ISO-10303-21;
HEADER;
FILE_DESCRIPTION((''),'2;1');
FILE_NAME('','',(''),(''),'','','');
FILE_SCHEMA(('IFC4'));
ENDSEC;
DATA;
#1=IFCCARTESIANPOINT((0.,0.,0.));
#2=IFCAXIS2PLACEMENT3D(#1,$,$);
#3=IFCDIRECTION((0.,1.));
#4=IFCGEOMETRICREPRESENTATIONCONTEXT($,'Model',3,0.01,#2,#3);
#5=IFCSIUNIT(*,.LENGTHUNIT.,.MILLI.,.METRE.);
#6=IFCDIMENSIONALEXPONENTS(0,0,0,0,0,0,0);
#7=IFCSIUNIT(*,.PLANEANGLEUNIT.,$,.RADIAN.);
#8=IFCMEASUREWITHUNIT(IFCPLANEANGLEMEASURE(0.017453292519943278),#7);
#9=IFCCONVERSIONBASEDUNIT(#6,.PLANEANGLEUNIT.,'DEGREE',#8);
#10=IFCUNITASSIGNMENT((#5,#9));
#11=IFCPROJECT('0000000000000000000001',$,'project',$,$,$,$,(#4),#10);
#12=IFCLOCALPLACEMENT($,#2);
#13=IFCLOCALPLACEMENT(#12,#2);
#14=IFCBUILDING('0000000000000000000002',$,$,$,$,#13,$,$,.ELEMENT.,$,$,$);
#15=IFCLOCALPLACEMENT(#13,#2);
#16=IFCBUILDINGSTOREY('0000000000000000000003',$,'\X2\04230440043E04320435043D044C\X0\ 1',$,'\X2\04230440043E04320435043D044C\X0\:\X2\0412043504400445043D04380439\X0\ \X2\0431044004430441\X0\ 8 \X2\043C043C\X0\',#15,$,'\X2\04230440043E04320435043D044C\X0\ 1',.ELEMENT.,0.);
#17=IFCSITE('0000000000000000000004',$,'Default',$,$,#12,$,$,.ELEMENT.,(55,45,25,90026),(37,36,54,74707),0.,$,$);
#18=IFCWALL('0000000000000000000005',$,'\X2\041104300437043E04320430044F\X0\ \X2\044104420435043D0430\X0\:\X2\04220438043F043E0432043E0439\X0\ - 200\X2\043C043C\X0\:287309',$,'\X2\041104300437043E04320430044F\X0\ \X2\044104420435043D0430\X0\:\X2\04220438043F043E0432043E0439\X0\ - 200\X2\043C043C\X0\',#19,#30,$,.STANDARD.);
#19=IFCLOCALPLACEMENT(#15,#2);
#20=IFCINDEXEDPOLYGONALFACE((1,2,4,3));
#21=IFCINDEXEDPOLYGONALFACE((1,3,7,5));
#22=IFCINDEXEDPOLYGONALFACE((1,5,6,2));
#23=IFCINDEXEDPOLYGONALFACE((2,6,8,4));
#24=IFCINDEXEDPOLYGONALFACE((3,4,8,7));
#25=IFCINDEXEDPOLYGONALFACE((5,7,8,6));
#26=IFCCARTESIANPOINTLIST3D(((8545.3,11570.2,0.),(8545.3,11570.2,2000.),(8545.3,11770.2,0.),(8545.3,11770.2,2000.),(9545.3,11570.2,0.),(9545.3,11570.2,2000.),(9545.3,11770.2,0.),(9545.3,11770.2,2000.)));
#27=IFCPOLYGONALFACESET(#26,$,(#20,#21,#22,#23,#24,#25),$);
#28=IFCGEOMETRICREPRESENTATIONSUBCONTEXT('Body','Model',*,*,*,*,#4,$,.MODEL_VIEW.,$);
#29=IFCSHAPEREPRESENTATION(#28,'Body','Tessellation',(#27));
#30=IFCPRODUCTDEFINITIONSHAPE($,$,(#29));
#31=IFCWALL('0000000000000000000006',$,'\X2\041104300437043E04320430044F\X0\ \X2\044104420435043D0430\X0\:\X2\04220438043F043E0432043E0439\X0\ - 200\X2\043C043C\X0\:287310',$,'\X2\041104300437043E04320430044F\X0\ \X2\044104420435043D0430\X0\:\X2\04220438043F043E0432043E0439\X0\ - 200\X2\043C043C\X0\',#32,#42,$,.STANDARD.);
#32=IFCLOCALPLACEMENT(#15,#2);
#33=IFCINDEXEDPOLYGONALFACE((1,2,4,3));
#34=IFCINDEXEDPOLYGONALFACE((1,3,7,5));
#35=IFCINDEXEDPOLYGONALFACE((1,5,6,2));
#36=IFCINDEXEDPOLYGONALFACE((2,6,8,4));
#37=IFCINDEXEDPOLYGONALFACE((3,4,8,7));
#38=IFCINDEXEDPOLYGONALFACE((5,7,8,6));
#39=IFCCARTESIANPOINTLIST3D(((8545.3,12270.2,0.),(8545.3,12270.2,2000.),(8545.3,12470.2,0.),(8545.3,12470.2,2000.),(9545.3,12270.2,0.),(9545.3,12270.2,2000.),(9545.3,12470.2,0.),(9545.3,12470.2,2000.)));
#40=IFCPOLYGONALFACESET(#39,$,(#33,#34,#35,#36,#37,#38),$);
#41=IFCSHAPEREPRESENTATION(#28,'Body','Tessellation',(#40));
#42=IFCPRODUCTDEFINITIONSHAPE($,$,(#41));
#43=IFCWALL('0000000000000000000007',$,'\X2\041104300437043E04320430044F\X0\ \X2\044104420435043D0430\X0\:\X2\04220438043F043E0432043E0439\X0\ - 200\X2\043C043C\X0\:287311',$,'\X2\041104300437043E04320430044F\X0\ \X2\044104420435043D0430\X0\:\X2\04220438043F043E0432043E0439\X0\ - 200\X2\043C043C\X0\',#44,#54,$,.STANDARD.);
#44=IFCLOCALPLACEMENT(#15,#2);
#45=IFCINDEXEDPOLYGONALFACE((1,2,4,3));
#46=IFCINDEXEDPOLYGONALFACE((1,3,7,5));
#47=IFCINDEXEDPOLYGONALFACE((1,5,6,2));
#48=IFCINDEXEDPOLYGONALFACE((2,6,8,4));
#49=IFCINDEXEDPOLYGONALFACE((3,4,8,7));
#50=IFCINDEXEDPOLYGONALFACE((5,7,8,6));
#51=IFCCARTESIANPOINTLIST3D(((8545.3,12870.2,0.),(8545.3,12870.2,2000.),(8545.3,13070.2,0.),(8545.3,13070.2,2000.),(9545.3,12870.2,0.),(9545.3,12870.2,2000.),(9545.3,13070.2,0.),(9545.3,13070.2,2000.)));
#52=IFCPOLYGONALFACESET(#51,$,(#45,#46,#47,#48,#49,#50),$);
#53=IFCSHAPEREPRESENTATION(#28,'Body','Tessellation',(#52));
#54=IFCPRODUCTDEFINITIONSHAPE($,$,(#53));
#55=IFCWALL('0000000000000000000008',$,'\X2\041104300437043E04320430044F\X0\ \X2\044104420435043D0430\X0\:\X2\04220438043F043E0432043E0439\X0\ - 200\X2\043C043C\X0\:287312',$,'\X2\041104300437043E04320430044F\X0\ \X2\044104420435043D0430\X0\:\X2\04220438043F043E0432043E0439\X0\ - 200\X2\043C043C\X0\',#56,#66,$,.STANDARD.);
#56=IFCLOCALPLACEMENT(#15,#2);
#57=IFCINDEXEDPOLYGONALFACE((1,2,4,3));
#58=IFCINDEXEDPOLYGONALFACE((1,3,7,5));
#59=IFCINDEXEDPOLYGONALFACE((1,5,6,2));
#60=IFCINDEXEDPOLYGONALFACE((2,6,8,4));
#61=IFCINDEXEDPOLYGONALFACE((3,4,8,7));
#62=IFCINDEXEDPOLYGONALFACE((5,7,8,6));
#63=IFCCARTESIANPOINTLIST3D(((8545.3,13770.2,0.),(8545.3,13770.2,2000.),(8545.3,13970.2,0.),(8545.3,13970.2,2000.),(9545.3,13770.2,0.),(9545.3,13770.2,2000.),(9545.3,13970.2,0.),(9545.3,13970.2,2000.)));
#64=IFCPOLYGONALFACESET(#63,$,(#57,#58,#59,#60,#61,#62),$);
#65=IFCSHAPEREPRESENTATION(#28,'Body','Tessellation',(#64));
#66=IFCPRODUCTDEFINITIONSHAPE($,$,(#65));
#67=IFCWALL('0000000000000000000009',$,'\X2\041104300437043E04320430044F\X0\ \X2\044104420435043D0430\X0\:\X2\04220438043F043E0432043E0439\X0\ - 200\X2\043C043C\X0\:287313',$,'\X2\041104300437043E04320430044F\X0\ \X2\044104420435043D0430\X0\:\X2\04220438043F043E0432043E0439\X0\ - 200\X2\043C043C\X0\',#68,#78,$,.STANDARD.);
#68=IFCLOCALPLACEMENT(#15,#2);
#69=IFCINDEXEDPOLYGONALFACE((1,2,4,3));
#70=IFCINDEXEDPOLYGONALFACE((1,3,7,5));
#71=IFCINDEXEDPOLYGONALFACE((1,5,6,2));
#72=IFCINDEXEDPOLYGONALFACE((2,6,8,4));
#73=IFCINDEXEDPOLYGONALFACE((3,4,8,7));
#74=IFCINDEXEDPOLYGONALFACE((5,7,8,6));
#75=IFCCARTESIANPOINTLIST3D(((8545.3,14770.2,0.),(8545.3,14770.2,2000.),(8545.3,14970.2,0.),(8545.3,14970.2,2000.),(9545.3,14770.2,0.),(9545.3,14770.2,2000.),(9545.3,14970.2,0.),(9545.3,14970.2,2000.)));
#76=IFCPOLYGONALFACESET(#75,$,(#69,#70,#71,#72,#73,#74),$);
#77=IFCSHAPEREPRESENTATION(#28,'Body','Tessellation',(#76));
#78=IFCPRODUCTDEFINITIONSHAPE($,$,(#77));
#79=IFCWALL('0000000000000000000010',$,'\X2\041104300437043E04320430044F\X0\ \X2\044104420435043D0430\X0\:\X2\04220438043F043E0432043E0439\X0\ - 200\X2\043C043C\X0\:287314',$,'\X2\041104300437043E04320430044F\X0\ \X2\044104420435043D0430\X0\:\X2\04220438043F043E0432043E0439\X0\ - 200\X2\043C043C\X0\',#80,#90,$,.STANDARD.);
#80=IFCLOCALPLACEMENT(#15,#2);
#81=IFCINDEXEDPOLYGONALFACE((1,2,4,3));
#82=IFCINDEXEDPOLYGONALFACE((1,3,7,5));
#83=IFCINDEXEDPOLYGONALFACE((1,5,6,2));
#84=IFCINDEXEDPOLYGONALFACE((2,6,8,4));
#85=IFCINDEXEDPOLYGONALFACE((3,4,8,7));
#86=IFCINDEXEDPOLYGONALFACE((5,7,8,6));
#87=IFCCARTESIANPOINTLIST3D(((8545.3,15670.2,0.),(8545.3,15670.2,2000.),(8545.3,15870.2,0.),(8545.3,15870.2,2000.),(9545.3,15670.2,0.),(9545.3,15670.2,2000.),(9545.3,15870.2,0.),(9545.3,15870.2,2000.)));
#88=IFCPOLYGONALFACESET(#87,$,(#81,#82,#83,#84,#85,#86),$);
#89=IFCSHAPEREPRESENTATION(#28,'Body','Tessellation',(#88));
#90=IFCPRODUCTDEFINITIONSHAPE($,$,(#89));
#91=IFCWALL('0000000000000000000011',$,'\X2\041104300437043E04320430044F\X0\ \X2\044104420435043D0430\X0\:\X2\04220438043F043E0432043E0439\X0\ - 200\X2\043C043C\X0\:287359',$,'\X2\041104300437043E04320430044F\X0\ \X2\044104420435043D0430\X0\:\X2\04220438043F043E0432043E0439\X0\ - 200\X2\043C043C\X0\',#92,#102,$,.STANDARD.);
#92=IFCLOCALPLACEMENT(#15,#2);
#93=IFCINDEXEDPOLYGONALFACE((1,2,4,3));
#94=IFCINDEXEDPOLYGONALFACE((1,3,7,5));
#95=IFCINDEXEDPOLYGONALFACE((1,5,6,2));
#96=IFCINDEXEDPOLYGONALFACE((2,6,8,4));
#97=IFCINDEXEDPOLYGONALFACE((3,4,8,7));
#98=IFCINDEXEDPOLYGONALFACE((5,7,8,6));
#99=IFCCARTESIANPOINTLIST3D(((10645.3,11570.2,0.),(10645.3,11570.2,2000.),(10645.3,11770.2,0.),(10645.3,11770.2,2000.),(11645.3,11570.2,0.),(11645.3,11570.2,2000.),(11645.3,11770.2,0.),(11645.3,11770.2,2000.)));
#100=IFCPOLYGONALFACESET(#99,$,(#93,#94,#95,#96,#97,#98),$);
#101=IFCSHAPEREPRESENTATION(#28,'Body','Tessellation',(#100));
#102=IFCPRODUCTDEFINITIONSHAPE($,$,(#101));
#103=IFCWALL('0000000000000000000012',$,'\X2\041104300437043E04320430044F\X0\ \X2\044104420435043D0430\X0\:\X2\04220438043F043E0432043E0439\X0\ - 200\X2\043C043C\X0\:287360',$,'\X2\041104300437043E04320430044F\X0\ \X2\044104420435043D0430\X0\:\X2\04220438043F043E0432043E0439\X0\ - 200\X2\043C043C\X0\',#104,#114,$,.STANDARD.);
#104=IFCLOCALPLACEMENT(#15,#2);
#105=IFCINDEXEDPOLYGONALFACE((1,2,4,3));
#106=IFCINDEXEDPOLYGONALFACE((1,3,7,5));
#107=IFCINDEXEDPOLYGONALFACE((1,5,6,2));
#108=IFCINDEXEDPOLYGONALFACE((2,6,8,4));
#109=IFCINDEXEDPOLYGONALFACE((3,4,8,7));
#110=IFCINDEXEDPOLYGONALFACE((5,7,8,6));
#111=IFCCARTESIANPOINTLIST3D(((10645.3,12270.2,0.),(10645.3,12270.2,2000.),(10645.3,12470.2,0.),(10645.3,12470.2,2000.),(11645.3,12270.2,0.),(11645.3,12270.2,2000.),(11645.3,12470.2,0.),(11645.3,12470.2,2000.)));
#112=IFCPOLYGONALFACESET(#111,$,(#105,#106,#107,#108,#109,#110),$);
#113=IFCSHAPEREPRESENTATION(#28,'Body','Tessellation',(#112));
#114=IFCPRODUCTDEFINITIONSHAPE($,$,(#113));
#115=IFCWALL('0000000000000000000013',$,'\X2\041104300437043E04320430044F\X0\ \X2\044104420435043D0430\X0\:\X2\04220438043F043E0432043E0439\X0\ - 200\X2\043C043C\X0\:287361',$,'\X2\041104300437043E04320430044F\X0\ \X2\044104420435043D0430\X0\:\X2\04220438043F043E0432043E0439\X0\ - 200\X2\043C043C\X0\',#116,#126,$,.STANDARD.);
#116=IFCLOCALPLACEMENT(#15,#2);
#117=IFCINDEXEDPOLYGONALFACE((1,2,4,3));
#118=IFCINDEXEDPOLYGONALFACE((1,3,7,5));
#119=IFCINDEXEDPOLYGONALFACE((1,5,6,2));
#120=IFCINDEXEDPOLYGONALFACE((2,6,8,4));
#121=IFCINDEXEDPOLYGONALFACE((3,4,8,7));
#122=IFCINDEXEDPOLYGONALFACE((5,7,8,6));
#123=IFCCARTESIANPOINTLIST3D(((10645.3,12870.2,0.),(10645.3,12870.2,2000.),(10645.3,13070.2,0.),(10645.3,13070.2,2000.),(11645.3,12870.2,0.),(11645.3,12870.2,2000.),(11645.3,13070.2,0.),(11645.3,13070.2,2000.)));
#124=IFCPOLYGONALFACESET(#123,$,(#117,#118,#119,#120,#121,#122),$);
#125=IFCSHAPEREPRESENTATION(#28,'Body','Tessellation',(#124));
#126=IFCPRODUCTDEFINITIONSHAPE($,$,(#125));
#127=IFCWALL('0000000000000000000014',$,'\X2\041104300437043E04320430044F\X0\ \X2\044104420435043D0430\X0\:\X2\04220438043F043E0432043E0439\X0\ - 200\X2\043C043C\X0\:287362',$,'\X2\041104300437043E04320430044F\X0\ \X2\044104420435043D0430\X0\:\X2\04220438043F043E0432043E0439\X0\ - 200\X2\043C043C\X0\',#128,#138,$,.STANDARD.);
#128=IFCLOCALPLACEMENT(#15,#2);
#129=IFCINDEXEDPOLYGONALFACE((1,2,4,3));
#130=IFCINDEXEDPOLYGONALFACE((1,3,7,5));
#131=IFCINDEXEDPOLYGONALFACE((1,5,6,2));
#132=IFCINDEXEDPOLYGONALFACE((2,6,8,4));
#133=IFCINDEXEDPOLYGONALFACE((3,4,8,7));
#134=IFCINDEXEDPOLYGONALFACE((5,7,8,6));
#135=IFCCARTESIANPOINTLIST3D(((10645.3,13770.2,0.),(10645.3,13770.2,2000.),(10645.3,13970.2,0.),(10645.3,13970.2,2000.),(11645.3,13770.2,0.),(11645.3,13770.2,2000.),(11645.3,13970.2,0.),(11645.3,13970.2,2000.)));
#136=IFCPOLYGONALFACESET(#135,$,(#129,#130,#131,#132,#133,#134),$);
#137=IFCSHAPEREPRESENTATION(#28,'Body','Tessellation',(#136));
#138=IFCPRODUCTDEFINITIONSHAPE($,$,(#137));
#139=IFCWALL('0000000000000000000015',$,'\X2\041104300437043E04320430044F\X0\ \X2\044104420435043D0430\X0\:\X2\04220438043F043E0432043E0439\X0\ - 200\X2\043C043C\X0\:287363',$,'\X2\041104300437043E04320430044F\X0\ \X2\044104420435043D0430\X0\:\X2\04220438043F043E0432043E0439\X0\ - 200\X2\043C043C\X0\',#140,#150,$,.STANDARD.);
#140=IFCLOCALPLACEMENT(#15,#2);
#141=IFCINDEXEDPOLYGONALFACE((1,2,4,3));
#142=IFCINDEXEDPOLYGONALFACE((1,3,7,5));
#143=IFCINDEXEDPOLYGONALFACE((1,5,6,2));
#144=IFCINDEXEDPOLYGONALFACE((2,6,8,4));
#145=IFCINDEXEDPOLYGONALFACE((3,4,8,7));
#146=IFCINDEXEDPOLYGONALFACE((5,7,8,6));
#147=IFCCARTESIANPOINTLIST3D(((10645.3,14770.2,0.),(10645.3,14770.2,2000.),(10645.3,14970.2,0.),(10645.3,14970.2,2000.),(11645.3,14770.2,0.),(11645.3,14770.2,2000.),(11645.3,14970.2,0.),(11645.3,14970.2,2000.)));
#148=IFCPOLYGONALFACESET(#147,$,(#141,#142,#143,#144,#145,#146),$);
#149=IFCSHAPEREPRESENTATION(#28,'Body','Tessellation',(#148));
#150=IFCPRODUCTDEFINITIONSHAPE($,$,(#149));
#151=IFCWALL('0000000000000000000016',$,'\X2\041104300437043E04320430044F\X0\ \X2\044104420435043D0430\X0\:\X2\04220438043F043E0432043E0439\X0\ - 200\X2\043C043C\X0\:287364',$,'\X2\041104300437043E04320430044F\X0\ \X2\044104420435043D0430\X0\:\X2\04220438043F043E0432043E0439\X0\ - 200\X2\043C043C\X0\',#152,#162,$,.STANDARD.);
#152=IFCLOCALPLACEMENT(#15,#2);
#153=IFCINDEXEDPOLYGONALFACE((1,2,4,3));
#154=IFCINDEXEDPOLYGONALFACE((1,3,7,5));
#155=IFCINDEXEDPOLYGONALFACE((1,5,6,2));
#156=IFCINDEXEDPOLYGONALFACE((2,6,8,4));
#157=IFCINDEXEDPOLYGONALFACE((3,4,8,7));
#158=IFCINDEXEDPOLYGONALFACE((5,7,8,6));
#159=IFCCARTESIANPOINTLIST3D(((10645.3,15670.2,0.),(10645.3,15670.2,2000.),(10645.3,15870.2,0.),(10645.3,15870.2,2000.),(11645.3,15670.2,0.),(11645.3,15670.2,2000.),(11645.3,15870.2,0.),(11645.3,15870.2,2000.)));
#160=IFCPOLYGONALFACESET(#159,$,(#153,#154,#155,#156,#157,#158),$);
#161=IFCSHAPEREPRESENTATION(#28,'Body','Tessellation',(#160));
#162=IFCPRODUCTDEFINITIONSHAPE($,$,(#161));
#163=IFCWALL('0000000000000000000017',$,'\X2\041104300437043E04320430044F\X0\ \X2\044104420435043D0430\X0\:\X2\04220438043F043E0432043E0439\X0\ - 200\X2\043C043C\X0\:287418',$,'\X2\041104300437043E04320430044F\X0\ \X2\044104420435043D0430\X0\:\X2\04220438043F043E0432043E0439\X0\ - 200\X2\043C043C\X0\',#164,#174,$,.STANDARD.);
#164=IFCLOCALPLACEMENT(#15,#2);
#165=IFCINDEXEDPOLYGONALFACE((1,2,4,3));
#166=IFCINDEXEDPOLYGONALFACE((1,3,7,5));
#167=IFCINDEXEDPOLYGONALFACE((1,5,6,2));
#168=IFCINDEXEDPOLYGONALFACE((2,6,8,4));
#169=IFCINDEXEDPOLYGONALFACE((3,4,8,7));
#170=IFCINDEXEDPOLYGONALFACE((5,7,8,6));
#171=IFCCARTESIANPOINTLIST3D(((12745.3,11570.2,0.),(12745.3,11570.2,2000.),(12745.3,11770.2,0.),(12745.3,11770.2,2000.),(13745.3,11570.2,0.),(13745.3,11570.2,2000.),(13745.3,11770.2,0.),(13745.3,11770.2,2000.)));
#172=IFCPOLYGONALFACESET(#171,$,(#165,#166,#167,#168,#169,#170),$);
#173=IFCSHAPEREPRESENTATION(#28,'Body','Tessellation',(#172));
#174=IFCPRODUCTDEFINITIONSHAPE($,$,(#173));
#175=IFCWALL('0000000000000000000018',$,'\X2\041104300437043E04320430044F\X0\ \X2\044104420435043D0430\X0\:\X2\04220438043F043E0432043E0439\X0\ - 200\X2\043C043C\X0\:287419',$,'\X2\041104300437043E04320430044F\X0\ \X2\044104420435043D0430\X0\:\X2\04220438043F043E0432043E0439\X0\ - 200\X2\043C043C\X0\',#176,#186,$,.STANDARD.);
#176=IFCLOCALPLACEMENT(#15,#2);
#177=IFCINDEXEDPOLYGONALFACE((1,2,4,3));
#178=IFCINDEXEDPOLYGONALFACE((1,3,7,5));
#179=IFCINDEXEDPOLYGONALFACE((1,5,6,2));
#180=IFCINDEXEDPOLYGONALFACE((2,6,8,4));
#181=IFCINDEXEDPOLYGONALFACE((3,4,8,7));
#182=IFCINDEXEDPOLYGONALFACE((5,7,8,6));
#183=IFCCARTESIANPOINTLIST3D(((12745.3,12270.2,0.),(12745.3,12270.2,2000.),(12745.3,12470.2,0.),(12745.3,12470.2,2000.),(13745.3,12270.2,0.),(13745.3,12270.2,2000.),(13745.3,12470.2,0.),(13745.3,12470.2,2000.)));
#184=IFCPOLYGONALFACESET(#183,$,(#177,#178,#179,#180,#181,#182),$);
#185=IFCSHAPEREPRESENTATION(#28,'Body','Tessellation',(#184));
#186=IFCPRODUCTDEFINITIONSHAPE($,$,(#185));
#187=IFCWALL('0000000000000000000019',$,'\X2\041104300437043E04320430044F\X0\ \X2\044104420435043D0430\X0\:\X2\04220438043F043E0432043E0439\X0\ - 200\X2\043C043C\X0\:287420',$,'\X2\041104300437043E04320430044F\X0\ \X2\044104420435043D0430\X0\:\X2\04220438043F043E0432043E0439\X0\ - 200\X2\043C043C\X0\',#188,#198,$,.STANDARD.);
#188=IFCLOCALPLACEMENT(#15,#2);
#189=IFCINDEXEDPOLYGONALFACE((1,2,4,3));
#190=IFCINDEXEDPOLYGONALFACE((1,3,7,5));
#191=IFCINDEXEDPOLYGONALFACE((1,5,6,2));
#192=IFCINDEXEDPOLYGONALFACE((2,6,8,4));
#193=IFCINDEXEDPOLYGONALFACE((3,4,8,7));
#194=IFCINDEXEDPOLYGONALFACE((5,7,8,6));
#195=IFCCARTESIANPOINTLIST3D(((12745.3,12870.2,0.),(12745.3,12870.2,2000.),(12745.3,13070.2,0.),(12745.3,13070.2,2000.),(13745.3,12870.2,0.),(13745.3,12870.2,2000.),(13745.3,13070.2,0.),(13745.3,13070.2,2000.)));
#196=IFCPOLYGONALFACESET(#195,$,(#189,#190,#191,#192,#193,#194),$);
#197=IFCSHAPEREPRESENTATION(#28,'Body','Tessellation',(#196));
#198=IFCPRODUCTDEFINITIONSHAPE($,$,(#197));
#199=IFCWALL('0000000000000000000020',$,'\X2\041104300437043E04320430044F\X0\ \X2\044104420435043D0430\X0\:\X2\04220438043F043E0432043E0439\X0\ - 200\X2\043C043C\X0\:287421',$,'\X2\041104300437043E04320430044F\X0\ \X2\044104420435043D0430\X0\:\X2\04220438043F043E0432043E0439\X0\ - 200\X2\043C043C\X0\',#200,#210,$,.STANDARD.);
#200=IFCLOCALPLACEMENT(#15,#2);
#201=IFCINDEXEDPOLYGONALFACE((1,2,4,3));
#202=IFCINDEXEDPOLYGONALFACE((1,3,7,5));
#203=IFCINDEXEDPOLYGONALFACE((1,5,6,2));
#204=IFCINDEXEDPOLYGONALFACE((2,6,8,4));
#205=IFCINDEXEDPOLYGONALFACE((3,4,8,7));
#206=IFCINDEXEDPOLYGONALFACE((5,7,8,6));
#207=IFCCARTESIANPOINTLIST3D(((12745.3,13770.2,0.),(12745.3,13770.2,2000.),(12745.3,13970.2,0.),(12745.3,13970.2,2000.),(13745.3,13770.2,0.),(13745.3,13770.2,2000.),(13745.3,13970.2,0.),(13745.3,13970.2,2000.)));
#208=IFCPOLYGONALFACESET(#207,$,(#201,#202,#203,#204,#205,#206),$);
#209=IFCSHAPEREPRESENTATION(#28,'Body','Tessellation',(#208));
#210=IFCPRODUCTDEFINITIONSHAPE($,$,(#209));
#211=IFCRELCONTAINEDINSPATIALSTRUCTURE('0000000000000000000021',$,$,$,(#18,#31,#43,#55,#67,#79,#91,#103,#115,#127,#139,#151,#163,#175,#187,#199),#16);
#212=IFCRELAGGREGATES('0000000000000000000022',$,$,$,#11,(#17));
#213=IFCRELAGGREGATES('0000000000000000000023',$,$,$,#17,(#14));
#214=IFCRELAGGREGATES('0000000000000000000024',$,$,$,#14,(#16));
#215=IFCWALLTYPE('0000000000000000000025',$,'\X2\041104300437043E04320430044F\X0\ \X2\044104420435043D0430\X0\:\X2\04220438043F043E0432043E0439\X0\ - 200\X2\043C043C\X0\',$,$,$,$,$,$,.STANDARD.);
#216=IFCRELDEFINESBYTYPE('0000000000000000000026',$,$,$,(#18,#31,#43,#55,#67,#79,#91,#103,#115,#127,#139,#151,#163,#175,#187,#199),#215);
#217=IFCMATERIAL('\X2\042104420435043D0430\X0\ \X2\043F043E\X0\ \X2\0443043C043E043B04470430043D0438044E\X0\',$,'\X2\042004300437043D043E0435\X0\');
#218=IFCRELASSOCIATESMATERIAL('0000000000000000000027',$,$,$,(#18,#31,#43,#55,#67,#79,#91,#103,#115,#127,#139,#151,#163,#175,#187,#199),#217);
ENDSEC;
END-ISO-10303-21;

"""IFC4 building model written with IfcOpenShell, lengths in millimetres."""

from ifc_helpers import new_model, entity, si_unit, converted_unit, direction, frame, origin, place, context, subcontext, project, spatial, indexed_curve, outline, extrude, material, type_object, element, save


model = new_model("IFC4")

# Units and contexts
model_context = context("Model", 3, precision=0.01, world=origin(), true_north=direction((0.0, 1.0)))
body_context = subcontext(model_context, "Body", "Model", "MODEL_VIEW")
ifc_project = project(units=[si_unit("LENGTHUNIT", "METRE", prefix="MILLI"), converted_unit("PLANEANGLEUNIT", "DEGREE", entity("IfcPlaneAngleMeasure", 0.017453292519943278), si_unit("PLANEANGLEUNIT", "RADIAN"), dimensions=[0, 0, 0, 0, 0, 0, 0])], contexts=[model_context])

# Site, building, storey
site_placement = place(None, origin())
site = spatial("IfcSite", under=ifc_project, at=site_placement, Name="Default", CompositionType="ELEMENT", RefLatitude=(55, 45, 25, 90026), RefLongitude=(37, 36, 54, 74707), RefElevation=0.0)
building_placement = place(site_placement, origin())
building = spatial("IfcBuilding", under=site, at=building_placement, CompositionType="ELEMENT")
storey_placement = place(building_placement, origin())
storey = spatial("IfcBuildingStorey", under=building, at=storey_placement, Name="Уровень 1", ObjectType="Уровень:Верхний брус 8 мм", LongName="Уровень 1", CompositionType="ELEMENT", Elevation=0.0)

# Walls
ifc_material = material(Name="Стена по умолчанию", Category="Разное")
wall_type = type_object("IfcWallType", Name="Базовая стена:Типовой - 200мм", PredefinedType="STANDARD")
for number, where, name in (
    (1, (8545.3, 11670.2, 0.0), "Базовая стена:Типовой - 200мм:287309"),
    (2, (8545.3, 12370.2, 0.0), "Базовая стена:Типовой - 200мм:287310"),
):
    element("IfcWall", number, at=place(storey_placement, frame(where)), inside=storey, type_object=wall_type, material=ifc_material, Name=name, ObjectType="Базовая стена:Типовой - 200мм", PredefinedType="STANDARD", context=body_context, shape_type="SweptSolid", body=[
        extrude(outline(indexed_curve([(1000.0, 100.0), (0.0, 100.0), (0.0, -100.0), (1000.0, -100.0), (1000.0, 100.0)], self_intersect=False)), origin(), (0.0, 0.0, 1.0), 2000.0),
    ])
wall_1_placement = place(storey_placement, frame((8545.3, 12970.2, 0.0)))
element("IfcWall", 3, at=wall_1_placement, inside=storey, type_object=wall_type, material=ifc_material, Name="Базовая стена:Типовой - 200мм:287311", ObjectType="Базовая стена:Типовой - 200мм", PredefinedType="STANDARD", context=body_context, shape_type="SweptSolid", body=[
    extrude(outline(indexed_curve([(1000.0, 100.0), (0.0, 100.0), (0.0, -100.0), (1000.0, -100.0), (1000.0, 100.0)], self_intersect=False)), origin(), (0.0, 0.0, 1.0), 2000.0),
])
wall_2_placement = place(storey_placement, frame((8545.3, 13870.2, 0.0)))
element("IfcWall", 4, at=wall_2_placement, inside=storey, type_object=wall_type, material=ifc_material, Name="Базовая стена:Типовой - 200мм:287312", ObjectType="Базовая стена:Типовой - 200мм", PredefinedType="STANDARD", context=body_context, shape_type="SweptSolid", body=[
    extrude(outline(indexed_curve([(1000.0, 100.0), (0.0, 100.0), (0.0, -100.0), (1000.0, -100.0), (1000.0, 100.0)], self_intersect=False)), origin(), (0.0, 0.0, 1.0), 2000.0),
])
for number, where, name in (
    (5, (8545.3, 14870.2, 0.0), "Базовая стена:Типовой - 200мм:287313"),
    (6, (8545.3, 15770.2, 0.0), "Базовая стена:Типовой - 200мм:287314"),
):
    element("IfcWall", number, at=place(storey_placement, frame(where)), inside=storey, type_object=wall_type, material=ifc_material, Name=name, ObjectType="Базовая стена:Типовой - 200мм", PredefinedType="STANDARD", context=body_context, shape_type="SweptSolid", body=[
        extrude(outline(indexed_curve([(1000.0, 100.0), (0.0, 100.0), (0.0, -100.0), (1000.0, -100.0), (1000.0, 100.0)], self_intersect=False)), origin(), (0.0, 0.0, 1.0), 2000.0),
    ])
for number, where, name in (
    (7, (10645.3, 11670.2, 0.0), "Базовая стена:Типовой - 200мм:287359"),
    (8, (10645.3, 12370.2, 0.0), "Базовая стена:Типовой - 200мм:287360"),
):
    element("IfcWall", number, at=place(storey_placement, frame(where)), inside=storey, type_object=wall_type, material=ifc_material, Name=name, ObjectType="Базовая стена:Типовой - 200мм", PredefinedType="STANDARD", context=body_context, shape_type="SweptSolid", body=[
        extrude(outline(indexed_curve([(1000.0, 100.0), (0.0, 100.0), (0.0, -100.0), (1000.0, -100.0), (1000.0, 100.0)], self_intersect=False)), origin(), (0.0, 0.0, 1.0), 2000.0),
    ])
wall_3_placement = place(storey_placement, frame((10645.3, 12970.2, 0.0)))
element("IfcWall", 9, at=wall_3_placement, inside=storey, type_object=wall_type, material=ifc_material, Name="Базовая стена:Типовой - 200мм:287361", ObjectType="Базовая стена:Типовой - 200мм", PredefinedType="STANDARD", context=body_context, shape_type="SweptSolid", body=[
    extrude(outline(indexed_curve([(1000.0, 100.0), (0.0, 100.0), (0.0, -100.0), (1000.0, -100.0), (1000.0, 100.0)], self_intersect=False)), origin(), (0.0, 0.0, 1.0), 2000.0),
])
wall_4_placement = place(storey_placement, frame((10645.3, 13870.2, 0.0)))
element("IfcWall", 10, at=wall_4_placement, inside=storey, type_object=wall_type, material=ifc_material, Name="Базовая стена:Типовой - 200мм:287362", ObjectType="Базовая стена:Типовой - 200мм", PredefinedType="STANDARD", context=body_context, shape_type="SweptSolid", body=[
    extrude(outline(indexed_curve([(1000.0, 100.0), (0.0, 100.0), (0.0, -100.0), (1000.0, -100.0), (1000.0, 100.0)], self_intersect=False)), origin(), (0.0, 0.0, 1.0), 2000.0),
])
for number, where, name in (
    (11, (10645.3, 14870.2, 0.0), "Базовая стена:Типовой - 200мм:287363"),
    (12, (10645.3, 15770.2, 0.0), "Базовая стена:Типовой - 200мм:287364"),
):
    element("IfcWall", number, at=place(storey_placement, frame(where)), inside=storey, type_object=wall_type, material=ifc_material, Name=name, ObjectType="Базовая стена:Типовой - 200мм", PredefinedType="STANDARD", context=body_context, shape_type="SweptSolid", body=[
        extrude(outline(indexed_curve([(1000.0, 100.0), (0.0, 100.0), (0.0, -100.0), (1000.0, -100.0), (1000.0, 100.0)], self_intersect=False)), origin(), (0.0, 0.0, 1.0), 2000.0),
    ])
for number, where, name in (
    (13, (12745.3, 11670.2, 0.0), "Базовая стена:Типовой - 200мм:287418"),
    (14, (12745.3, 12370.2, 0.0), "Базовая стена:Типовой - 200мм:287419"),
):
    element("IfcWall", number, at=place(storey_placement, frame(where)), inside=storey, type_object=wall_type, material=ifc_material, Name=name, ObjectType="Базовая стена:Типовой - 200мм", PredefinedType="STANDARD", context=body_context, shape_type="SweptSolid", body=[
        extrude(outline(indexed_curve([(1000.0, 100.0), (0.0, 100.0), (0.0, -100.0), (1000.0, -100.0), (1000.0, 100.0)], self_intersect=False)), origin(), (0.0, 0.0, 1.0), 2000.0),
    ])
wall_5_placement = place(storey_placement, frame((12745.3, 12970.2, 0.0)))
element("IfcWall", 15, at=wall_5_placement, inside=storey, type_object=wall_type, material=ifc_material, Name="Базовая стена:Типовой - 200мм:287420", ObjectType="Базовая стена:Типовой - 200мм", PredefinedType="STANDARD", context=body_context, shape_type="SweptSolid", body=[
    extrude(outline(indexed_curve([(1000.0, 100.0), (0.0, 100.0), (0.0, -100.0), (1000.0, -100.0), (1000.0, 100.0)], self_intersect=False)), origin(), (0.0, 0.0, 1.0), 2000.0),
])
wall_6_placement = place(storey_placement, frame((12745.3, 13870.2, 0.0)))
element("IfcWall", 16, at=wall_6_placement, inside=storey, type_object=wall_type, material=ifc_material, Name="Базовая стена:Типовой - 200мм:287421", ObjectType="Базовая стена:Типовой - 200мм", PredefinedType="STANDARD", context=body_context, shape_type="SweptSolid", body=[
    extrude(outline(indexed_curve([(1000.0, 100.0), (0.0, 100.0), (0.0, -100.0), (1000.0, -100.0), (1000.0, 100.0)], self_intersect=False)), origin(), (0.0, 0.0, 1.0), 2000.0),
])

save(model, "model.ifc")
